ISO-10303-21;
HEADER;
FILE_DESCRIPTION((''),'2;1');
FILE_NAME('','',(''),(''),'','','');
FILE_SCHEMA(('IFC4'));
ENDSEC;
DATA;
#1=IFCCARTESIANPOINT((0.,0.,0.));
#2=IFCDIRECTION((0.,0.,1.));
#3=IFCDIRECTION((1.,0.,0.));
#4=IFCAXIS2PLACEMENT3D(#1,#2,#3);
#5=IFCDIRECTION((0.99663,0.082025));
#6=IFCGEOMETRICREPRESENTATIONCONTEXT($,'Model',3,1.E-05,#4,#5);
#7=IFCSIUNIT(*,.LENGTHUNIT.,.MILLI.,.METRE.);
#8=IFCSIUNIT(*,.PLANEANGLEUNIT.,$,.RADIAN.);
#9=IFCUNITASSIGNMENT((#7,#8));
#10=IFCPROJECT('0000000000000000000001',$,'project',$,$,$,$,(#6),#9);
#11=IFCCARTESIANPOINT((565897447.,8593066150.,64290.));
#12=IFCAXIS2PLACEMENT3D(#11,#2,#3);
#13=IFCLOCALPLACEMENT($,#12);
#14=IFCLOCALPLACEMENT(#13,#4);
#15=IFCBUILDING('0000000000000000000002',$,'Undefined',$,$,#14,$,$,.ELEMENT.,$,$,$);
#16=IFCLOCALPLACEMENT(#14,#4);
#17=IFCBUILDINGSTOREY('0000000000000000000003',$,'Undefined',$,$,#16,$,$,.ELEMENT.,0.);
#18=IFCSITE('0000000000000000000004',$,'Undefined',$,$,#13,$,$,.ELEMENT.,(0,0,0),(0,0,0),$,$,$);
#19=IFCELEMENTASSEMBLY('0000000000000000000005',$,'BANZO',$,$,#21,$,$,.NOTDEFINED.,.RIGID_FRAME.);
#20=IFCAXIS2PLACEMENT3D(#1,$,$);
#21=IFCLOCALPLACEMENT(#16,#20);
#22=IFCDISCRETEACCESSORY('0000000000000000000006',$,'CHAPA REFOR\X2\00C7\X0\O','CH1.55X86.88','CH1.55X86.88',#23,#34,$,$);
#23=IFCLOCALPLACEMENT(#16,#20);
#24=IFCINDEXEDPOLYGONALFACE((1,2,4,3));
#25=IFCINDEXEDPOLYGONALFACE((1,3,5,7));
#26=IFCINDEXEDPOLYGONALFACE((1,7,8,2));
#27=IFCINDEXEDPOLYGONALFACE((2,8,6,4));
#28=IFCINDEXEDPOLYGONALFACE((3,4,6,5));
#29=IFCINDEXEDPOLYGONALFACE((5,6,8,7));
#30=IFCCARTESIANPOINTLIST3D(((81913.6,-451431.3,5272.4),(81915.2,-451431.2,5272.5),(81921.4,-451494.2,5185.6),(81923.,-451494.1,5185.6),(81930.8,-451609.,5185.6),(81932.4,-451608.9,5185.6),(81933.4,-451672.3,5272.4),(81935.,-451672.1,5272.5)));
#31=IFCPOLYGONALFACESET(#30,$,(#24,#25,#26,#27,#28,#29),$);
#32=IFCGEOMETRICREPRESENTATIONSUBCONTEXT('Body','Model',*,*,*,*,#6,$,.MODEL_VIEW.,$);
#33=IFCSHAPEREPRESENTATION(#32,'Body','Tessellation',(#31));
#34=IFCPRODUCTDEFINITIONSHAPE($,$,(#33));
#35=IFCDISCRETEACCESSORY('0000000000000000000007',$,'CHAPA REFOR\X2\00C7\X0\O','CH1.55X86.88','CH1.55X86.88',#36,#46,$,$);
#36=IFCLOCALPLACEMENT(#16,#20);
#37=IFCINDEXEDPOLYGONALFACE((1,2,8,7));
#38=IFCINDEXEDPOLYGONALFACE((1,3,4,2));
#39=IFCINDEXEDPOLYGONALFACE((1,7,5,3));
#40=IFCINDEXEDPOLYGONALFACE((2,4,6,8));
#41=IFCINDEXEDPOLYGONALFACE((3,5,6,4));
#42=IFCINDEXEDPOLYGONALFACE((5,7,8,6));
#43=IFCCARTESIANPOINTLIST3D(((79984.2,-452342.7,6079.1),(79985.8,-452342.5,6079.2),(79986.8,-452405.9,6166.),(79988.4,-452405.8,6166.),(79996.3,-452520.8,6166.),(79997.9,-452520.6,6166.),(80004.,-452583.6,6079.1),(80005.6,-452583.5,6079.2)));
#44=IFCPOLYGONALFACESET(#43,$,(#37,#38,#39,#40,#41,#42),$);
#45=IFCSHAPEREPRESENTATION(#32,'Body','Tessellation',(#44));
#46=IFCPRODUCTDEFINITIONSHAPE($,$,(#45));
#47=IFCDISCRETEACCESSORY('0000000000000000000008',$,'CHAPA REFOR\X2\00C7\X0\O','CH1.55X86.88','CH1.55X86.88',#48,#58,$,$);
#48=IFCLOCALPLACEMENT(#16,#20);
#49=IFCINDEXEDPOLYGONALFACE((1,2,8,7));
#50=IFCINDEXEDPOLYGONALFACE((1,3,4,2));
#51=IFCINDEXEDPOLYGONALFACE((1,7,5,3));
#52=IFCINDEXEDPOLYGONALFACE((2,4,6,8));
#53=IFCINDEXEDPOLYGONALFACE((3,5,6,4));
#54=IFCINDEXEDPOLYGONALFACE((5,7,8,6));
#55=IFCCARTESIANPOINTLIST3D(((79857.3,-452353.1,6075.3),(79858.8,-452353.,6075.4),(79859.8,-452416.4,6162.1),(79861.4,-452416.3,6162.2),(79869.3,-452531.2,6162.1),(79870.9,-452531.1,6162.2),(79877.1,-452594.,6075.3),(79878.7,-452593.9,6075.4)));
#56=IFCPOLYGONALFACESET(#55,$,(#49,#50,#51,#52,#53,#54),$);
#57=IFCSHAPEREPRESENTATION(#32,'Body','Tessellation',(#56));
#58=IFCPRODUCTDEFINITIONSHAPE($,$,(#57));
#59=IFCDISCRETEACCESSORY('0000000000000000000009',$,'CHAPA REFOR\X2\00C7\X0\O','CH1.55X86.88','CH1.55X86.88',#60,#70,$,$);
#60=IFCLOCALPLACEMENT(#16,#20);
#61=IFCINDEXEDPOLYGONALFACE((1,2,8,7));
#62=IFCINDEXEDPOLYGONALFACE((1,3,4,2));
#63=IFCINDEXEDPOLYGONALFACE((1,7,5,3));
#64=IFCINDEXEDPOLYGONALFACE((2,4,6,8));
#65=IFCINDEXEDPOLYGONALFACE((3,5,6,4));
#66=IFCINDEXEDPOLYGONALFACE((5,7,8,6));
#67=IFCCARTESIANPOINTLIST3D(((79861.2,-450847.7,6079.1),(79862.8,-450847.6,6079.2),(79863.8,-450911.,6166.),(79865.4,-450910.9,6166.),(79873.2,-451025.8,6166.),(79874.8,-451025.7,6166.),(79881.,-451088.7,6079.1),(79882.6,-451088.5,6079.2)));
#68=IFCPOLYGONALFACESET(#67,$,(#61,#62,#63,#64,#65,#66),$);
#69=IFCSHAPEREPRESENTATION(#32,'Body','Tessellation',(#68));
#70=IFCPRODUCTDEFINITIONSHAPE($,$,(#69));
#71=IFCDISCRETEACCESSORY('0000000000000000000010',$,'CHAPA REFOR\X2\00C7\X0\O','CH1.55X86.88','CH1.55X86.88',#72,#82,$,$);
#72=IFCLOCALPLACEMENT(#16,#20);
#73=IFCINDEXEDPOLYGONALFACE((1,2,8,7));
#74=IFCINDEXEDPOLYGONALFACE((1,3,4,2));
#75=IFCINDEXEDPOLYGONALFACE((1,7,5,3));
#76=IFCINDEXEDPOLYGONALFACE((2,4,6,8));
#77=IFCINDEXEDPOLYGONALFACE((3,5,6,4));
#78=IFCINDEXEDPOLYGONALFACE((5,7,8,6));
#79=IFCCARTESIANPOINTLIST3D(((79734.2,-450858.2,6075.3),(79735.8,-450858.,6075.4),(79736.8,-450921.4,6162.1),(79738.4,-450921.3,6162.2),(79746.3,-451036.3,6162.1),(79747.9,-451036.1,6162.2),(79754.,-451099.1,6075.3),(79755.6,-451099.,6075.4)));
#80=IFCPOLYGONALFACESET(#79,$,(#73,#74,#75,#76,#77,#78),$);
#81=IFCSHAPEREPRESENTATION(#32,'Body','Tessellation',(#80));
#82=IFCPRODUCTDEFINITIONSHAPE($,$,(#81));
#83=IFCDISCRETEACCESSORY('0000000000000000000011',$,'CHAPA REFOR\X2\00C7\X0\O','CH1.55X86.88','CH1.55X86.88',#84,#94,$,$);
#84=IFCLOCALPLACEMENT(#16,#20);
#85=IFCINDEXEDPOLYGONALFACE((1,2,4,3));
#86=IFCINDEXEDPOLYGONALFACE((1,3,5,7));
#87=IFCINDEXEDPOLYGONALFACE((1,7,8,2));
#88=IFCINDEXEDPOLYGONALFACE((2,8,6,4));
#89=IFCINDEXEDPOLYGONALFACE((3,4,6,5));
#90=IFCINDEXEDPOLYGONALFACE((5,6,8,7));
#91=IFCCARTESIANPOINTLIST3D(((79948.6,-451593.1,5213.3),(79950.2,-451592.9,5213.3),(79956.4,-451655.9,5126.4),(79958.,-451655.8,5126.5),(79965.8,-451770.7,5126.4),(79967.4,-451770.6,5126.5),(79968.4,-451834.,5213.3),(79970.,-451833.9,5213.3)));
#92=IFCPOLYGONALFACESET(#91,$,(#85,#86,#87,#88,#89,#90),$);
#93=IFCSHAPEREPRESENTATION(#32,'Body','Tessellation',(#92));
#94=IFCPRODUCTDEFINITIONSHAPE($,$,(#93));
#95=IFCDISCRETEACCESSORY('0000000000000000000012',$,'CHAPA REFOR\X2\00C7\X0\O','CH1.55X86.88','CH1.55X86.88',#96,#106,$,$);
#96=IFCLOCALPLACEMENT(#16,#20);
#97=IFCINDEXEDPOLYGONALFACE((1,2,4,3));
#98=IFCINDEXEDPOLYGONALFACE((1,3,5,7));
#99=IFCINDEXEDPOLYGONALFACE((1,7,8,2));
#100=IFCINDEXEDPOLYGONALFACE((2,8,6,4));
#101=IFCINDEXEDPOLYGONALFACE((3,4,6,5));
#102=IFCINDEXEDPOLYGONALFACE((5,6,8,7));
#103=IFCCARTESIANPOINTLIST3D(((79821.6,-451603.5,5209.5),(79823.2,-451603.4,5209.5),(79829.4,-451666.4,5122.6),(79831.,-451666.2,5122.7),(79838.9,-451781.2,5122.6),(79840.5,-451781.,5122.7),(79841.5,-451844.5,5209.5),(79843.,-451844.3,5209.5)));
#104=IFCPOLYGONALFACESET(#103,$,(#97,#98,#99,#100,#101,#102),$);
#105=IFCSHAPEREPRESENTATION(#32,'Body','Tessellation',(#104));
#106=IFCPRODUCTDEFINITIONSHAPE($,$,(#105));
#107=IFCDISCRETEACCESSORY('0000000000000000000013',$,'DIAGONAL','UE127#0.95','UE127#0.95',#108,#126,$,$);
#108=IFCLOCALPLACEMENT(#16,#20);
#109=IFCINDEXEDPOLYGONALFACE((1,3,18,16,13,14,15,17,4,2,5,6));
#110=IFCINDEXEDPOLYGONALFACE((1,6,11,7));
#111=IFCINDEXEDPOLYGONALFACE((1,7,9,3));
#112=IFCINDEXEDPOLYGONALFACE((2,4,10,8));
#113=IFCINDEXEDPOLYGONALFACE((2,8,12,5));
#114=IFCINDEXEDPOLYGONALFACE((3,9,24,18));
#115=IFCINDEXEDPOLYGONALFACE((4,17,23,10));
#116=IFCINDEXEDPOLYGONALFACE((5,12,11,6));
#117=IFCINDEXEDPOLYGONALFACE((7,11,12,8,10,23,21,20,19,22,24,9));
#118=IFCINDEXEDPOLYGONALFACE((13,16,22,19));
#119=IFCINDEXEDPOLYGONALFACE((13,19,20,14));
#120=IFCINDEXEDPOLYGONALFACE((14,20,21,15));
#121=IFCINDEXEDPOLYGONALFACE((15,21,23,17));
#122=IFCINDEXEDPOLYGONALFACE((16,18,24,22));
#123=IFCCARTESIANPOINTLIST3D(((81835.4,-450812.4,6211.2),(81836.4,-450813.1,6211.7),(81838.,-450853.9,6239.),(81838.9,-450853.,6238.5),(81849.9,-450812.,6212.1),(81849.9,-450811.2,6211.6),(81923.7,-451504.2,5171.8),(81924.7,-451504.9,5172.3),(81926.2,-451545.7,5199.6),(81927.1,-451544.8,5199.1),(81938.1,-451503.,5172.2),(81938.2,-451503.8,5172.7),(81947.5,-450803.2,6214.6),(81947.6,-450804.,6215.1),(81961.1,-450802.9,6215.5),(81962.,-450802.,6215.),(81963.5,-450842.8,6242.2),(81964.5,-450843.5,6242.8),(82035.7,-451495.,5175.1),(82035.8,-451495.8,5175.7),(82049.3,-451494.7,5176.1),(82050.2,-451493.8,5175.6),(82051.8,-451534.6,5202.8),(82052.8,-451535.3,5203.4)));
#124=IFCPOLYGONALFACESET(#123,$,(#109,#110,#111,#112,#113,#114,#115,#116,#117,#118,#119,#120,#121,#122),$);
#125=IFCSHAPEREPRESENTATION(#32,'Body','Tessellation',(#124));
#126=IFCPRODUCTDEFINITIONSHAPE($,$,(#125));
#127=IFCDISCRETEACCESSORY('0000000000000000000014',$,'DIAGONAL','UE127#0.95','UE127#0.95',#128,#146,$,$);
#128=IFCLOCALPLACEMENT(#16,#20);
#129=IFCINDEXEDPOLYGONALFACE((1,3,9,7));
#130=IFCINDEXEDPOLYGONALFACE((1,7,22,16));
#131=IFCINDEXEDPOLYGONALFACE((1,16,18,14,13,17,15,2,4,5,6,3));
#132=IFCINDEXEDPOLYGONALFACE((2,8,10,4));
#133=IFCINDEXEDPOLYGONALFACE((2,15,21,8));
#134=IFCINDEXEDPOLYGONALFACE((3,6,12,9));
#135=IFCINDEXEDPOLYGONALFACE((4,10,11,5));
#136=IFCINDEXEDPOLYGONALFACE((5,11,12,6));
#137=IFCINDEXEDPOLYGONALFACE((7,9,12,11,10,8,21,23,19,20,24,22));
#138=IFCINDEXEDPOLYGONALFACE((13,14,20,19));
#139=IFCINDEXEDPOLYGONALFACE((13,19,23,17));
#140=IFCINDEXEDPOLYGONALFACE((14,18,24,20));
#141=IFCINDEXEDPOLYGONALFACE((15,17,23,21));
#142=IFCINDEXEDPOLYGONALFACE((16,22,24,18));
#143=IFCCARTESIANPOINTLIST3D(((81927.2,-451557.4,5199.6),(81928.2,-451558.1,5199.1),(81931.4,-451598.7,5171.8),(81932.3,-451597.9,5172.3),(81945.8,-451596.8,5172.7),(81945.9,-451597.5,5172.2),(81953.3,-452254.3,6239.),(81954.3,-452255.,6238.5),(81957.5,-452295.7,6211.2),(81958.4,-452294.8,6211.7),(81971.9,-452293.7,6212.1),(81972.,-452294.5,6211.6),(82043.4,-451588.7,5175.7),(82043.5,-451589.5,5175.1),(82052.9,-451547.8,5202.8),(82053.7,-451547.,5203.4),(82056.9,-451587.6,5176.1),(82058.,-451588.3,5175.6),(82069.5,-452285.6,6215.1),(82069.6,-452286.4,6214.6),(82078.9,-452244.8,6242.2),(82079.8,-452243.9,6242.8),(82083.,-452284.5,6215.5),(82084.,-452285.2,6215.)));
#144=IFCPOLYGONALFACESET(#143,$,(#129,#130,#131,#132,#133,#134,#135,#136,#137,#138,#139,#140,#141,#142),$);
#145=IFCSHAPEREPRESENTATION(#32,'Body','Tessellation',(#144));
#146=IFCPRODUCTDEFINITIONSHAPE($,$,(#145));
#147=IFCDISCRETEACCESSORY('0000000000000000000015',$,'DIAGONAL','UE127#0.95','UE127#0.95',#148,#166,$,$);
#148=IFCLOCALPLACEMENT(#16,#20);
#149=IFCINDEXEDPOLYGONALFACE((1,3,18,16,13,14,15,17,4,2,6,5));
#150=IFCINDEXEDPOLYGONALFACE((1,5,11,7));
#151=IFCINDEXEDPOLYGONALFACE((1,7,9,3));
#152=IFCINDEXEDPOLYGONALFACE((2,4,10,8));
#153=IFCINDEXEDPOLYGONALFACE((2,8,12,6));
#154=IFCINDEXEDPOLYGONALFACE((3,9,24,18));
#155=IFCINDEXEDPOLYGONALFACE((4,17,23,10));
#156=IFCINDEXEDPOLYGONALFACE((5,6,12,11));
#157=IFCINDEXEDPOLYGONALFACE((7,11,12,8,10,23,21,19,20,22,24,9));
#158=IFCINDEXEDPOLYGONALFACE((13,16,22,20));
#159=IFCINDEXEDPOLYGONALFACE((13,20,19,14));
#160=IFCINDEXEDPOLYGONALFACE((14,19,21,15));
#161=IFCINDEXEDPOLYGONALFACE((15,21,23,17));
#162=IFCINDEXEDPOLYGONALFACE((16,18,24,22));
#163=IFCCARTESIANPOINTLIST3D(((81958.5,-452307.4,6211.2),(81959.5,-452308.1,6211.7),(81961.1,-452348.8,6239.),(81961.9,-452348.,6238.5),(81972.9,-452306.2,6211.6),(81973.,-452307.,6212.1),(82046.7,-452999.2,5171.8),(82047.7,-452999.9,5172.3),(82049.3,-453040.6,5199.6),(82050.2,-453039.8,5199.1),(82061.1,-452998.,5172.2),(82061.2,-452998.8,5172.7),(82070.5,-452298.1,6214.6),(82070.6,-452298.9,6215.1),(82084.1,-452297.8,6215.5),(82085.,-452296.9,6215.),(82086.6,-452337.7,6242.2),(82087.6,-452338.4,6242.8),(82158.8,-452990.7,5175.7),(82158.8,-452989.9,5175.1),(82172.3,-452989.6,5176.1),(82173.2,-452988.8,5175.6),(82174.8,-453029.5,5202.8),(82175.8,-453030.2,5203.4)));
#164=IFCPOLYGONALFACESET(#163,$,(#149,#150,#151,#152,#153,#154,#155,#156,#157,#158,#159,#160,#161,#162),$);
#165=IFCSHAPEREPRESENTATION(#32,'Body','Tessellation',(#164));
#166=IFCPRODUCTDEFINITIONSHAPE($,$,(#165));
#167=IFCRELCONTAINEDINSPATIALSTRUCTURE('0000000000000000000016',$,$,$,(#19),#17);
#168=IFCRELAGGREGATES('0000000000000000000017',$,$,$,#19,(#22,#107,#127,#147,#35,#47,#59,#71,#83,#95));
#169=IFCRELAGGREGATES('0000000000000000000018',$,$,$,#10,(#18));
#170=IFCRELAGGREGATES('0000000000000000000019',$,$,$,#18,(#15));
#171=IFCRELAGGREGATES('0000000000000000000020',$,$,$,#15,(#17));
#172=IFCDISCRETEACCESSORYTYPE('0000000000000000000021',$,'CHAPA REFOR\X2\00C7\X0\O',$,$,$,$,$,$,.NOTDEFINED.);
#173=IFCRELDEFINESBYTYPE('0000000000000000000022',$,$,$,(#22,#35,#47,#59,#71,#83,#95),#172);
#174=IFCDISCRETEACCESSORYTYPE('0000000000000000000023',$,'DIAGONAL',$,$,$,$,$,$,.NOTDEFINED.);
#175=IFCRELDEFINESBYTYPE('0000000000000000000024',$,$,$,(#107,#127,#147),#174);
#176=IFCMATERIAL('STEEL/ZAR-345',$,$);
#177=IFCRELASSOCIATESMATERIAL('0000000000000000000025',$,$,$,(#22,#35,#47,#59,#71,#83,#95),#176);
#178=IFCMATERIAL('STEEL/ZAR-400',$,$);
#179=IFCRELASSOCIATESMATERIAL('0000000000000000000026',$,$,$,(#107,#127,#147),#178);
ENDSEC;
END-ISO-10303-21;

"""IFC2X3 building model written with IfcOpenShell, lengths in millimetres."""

from ifc_helpers import new_model, si_unit, direction, frame, frame_2d, origin_with_axes, place, context, subcontext, project, spatial, polyline, c_section, outline, extrude, material, type_object, element, aggregate, save


model = new_model("IFC2X3")

# Units and contexts
model_context = context("Model", 3, precision=1e-05, world=origin_with_axes(), true_north=direction((0.99663, 0.082025)))
body_context = subcontext(model_context, "Body", "Model", "MODEL_VIEW")
ifc_project = project(units=[si_unit("LENGTHUNIT", "METRE", prefix="MILLI"), si_unit("PLANEANGLEUNIT", "RADIAN")], contexts=[model_context])

# Site, building, storey
site_placement = place(None, frame((565897447.0, 8593066150.0, 64290.0), z_axis=(0.0, 0.0, 1.0), x_axis=(1.0, 0.0, 0.0)))
site = spatial("IfcSite", under=ifc_project, at=site_placement, Name="Undefined", CompositionType="ELEMENT", RefLatitude=(0, 0, 0), RefLongitude=(0, 0, 0))
building_placement = place(site_placement, origin_with_axes())
building = spatial("IfcBuilding", under=site, at=building_placement, Name="Undefined", CompositionType="ELEMENT")
storey_placement = place(building_placement, origin_with_axes())
storey = spatial("IfcBuildingStorey", under=building, at=storey_placement, Name="Undefined", CompositionType="ELEMENT", Elevation=0.0)

# Element assembly, discrete accessories
assembly_1_placement = place(storey_placement, origin_with_axes())
assembly_1 = element("IfcElementAssembly", 1, at=assembly_1_placement, inside=storey, Name="BANZO", AssemblyPlace="NOTDEFINED", PredefinedType="RIGID_FRAME")
ifc_material_1 = material(Name="STEEL/ZAR-345")
discrete_accessory_type_1 = type_object("IfcDiscreteAccessoryType", Name="CHAPA REFORÇO")
discrete_accessory_1_placement = place(assembly_1_placement, frame((81914.4, -451431.3, 5272.5), z_axis=(0.996182, 0.081989, 0.029987), x_axis=(0.082025, -0.99663, 0.0)))
discrete_accessory_1 = element("IfcDiscreteAccessory", 2, at=discrete_accessory_1_placement, type_object=discrete_accessory_type_1, material=ifc_material_1, Name="CHAPA REFORÇO", Description="CH1.55X86.88", ObjectType="CH1.55X86.88", context=body_context, shape_type="SweptSolid", body=[
    extrude(outline(polyline([(0.0, 0.0), (241.7, 0.0), (178.5, 86.9), (63.3, 86.9), (0.0, 0.0)])), frame((0.0, 0.0, -0.8), z_axis=(0.0, 0.0, 1.0), x_axis=(1.0, 0.0, 0.0)), (0.0, 0.0, 1.0), 1.6),
])
discrete_accessory_2_placement = place(assembly_1_placement, frame((80004.8, -452583.5, 6079.2), z_axis=(0.996182, 0.081989, 0.029987), x_axis=(-0.082025, 0.99663, 0.0)))
discrete_accessory_2 = element("IfcDiscreteAccessory", 3, at=discrete_accessory_2_placement, type_object=discrete_accessory_type_1, material=ifc_material_1, Name="CHAPA REFORÇO", Description="CH1.55X86.88", ObjectType="CH1.55X86.88", context=body_context, shape_type="SweptSolid", body=[
    extrude(outline(polyline([(0.0, 0.0), (241.7, 0.0), (178.5, 86.9), (63.3, 86.9), (0.0, 0.0)])), frame((0.0, 0.0, -0.8), z_axis=(0.0, 0.0, 1.0), x_axis=(1.0, 0.0, 0.0)), (0.0, 0.0, 1.0), 1.6),
])
discrete_accessory_3_placement = place(assembly_1_placement, frame((79877.9, -452594.0, 6075.3), z_axis=(0.996182, 0.081989, 0.029987), x_axis=(-0.082025, 0.99663, 0.0)))
discrete_accessory_3 = element("IfcDiscreteAccessory", 4, at=discrete_accessory_3_placement, type_object=discrete_accessory_type_1, material=ifc_material_1, Name="CHAPA REFORÇO", Description="CH1.55X86.88", ObjectType="CH1.55X86.88", context=body_context, shape_type="SweptSolid", body=[
    extrude(outline(polyline([(0.0, 0.0), (241.7, 0.0), (178.5, 86.9), (63.3, 86.9), (0.0, 0.0)])), frame((0.0, 0.0, -0.8), z_axis=(0.0, 0.0, 1.0), x_axis=(1.0, 0.0, 0.0)), (0.0, 0.0, 1.0), 1.6),
])
discrete_accessory_4_placement = place(assembly_1_placement, frame((79881.8, -451088.6, 6079.2), z_axis=(0.996182, 0.081989, 0.029987), x_axis=(-0.082025, 0.99663, 0.0)))
discrete_accessory_4 = element("IfcDiscreteAccessory", 5, at=discrete_accessory_4_placement, type_object=discrete_accessory_type_1, material=ifc_material_1, Name="CHAPA REFORÇO", Description="CH1.55X86.88", ObjectType="CH1.55X86.88", context=body_context, shape_type="SweptSolid", body=[
    extrude(outline(polyline([(0.0, 0.0), (241.7, 0.0), (178.5, 86.9), (63.3, 86.9), (0.0, 0.0)])), frame((0.0, 0.0, -0.8), z_axis=(0.0, 0.0, 1.0), x_axis=(1.0, 0.0, 0.0)), (0.0, 0.0, 1.0), 1.6),
])
discrete_accessory_5_placement = place(assembly_1_placement, frame((79754.8, -451099.0, 6075.3), z_axis=(0.996182, 0.081989, 0.029987), x_axis=(-0.082025, 0.99663, 0.0)))
discrete_accessory_5 = element("IfcDiscreteAccessory", 6, at=discrete_accessory_5_placement, type_object=discrete_accessory_type_1, material=ifc_material_1, Name="CHAPA REFORÇO", Description="CH1.55X86.88", ObjectType="CH1.55X86.88", context=body_context, shape_type="SweptSolid", body=[
    extrude(outline(polyline([(0.0, 0.0), (241.7, 0.0), (178.5, 86.9), (63.3, 86.9), (0.0, 0.0)])), frame((0.0, 0.0, -0.8), z_axis=(0.0, 0.0, 1.0), x_axis=(1.0, 0.0, 0.0)), (0.0, 0.0, 1.0), 1.6),
])
discrete_accessory_6_placement = place(assembly_1_placement, frame((79949.4, -451593.0, 5213.3), z_axis=(0.996182, 0.081989, 0.029987), x_axis=(0.082025, -0.99663, 0.0)))
discrete_accessory_6 = element("IfcDiscreteAccessory", 7, at=discrete_accessory_6_placement, type_object=discrete_accessory_type_1, material=ifc_material_1, Name="CHAPA REFORÇO", Description="CH1.55X86.88", ObjectType="CH1.55X86.88", context=body_context, shape_type="SweptSolid", body=[
    extrude(outline(polyline([(0.0, 0.0), (241.7, 0.0), (178.5, 86.9), (63.3, 86.9), (0.0, 0.0)])), frame((0.0, 0.0, -0.8), z_axis=(0.0, 0.0, 1.0), x_axis=(1.0, 0.0, 0.0)), (0.0, 0.0, 1.0), 1.6),
])
discrete_accessory_7_placement = place(assembly_1_placement, frame((79822.4, -451603.5, 5209.5), z_axis=(0.996182, 0.081989, 0.029987), x_axis=(0.082025, -0.99663, 0.0)))
discrete_accessory_7 = element("IfcDiscreteAccessory", 8, at=discrete_accessory_7_placement, type_object=discrete_accessory_type_1, material=ifc_material_1, Name="CHAPA REFORÇO", Description="CH1.55X86.88", ObjectType="CH1.55X86.88", context=body_context, shape_type="SweptSolid", body=[
    extrude(outline(polyline([(0.0, 0.0), (241.7, 0.0), (178.5, 86.9), (63.3, 86.9), (0.0, 0.0)])), frame((0.0, 0.0, -0.8), z_axis=(0.0, 0.0, 1.0), x_axis=(1.0, 0.0, 0.0)), (0.0, 0.0, 1.0), 1.6),
])
ifc_material_2 = material(Name="STEEL/ZAR-400")
discrete_accessory_type_2 = type_object("IfcDiscreteAccessoryType", Name="DIAGONAL")
discrete_accessory_8_placement = place(assembly_1_placement, frame((81900.0, -450827.9, 6227.0), z_axis=(-0.996182, -0.081989, -0.029987), x_axis=(0.070485, -0.552697, -0.830396)))
discrete_accessory_8 = element("IfcDiscreteAccessory", 9, at=discrete_accessory_8_placement, type_object=discrete_accessory_type_2, material=ifc_material_2, Name="DIAGONAL", Description="UE127#0.95", ObjectType="UE127#0.95", context=body_context, shape_type="SweptSolid", body=[
    extrude(c_section(Depth=127.0, Width=50.0, WallThickness=0.9, Girth=14.5, at=frame_2d((0.0, 0.0), x_axis=(1.0, 0.0))), frame((1251.7, 0.0, 0.0), z_axis=(-1.0, 0.0, 0.0), x_axis=(0.0, -1.0, 0.0)), (0.0, 0.0, 1.0), 1251.7),
])
discrete_accessory_9_placement = place(assembly_1_placement, frame((81992.6, -451572.9, 5187.6), z_axis=(-0.996182, -0.081989, -0.029987), x_axis=(0.020829, -0.556784, 0.830396)))
discrete_accessory_9 = element("IfcDiscreteAccessory", 10, at=discrete_accessory_9_placement, type_object=discrete_accessory_type_2, material=ifc_material_2, Name="DIAGONAL", Description="UE127#0.95", ObjectType="UE127#0.95", context=body_context, shape_type="SweptSolid", body=[
    extrude(c_section(Depth=127.0, Width=50.0, WallThickness=0.9, Girth=14.5, at=frame_2d((0.0, 0.0), x_axis=(1.0, 0.0))), frame((1251.7, 0.0, 0.0), z_axis=(-1.0, 0.0, 0.0), x_axis=(0.0, -1.0, 0.0)), (0.0, 0.0, 1.0), 1251.7),
])
discrete_accessory_10_placement = place(assembly_1_placement, frame((82023.0, -452322.9, 6227.0), z_axis=(-0.996182, -0.081989, -0.029987), x_axis=(0.070485, -0.552697, -0.830396)))
discrete_accessory_10 = element("IfcDiscreteAccessory", 11, at=discrete_accessory_10_placement, type_object=discrete_accessory_type_2, material=ifc_material_2, Name="DIAGONAL", Description="UE127#0.95", ObjectType="UE127#0.95", context=body_context, shape_type="SweptSolid", body=[
    extrude(c_section(Depth=127.0, Width=50.0, WallThickness=0.9, Girth=14.5, at=frame_2d((0.0, 0.0), x_axis=(1.0, 0.0))), frame((1251.7, 0.0, 0.0), z_axis=(-1.0, 0.0, 0.0), x_axis=(0.0, -1.0, 0.0)), (0.0, 0.0, 1.0), 1251.7),
])
aggregate(assembly_1, [discrete_accessory_1, discrete_accessory_8, discrete_accessory_9, discrete_accessory_10, discrete_accessory_2, discrete_accessory_3, discrete_accessory_4, discrete_accessory_5, discrete_accessory_6, discrete_accessory_7])

save(model, "model.ifc")
